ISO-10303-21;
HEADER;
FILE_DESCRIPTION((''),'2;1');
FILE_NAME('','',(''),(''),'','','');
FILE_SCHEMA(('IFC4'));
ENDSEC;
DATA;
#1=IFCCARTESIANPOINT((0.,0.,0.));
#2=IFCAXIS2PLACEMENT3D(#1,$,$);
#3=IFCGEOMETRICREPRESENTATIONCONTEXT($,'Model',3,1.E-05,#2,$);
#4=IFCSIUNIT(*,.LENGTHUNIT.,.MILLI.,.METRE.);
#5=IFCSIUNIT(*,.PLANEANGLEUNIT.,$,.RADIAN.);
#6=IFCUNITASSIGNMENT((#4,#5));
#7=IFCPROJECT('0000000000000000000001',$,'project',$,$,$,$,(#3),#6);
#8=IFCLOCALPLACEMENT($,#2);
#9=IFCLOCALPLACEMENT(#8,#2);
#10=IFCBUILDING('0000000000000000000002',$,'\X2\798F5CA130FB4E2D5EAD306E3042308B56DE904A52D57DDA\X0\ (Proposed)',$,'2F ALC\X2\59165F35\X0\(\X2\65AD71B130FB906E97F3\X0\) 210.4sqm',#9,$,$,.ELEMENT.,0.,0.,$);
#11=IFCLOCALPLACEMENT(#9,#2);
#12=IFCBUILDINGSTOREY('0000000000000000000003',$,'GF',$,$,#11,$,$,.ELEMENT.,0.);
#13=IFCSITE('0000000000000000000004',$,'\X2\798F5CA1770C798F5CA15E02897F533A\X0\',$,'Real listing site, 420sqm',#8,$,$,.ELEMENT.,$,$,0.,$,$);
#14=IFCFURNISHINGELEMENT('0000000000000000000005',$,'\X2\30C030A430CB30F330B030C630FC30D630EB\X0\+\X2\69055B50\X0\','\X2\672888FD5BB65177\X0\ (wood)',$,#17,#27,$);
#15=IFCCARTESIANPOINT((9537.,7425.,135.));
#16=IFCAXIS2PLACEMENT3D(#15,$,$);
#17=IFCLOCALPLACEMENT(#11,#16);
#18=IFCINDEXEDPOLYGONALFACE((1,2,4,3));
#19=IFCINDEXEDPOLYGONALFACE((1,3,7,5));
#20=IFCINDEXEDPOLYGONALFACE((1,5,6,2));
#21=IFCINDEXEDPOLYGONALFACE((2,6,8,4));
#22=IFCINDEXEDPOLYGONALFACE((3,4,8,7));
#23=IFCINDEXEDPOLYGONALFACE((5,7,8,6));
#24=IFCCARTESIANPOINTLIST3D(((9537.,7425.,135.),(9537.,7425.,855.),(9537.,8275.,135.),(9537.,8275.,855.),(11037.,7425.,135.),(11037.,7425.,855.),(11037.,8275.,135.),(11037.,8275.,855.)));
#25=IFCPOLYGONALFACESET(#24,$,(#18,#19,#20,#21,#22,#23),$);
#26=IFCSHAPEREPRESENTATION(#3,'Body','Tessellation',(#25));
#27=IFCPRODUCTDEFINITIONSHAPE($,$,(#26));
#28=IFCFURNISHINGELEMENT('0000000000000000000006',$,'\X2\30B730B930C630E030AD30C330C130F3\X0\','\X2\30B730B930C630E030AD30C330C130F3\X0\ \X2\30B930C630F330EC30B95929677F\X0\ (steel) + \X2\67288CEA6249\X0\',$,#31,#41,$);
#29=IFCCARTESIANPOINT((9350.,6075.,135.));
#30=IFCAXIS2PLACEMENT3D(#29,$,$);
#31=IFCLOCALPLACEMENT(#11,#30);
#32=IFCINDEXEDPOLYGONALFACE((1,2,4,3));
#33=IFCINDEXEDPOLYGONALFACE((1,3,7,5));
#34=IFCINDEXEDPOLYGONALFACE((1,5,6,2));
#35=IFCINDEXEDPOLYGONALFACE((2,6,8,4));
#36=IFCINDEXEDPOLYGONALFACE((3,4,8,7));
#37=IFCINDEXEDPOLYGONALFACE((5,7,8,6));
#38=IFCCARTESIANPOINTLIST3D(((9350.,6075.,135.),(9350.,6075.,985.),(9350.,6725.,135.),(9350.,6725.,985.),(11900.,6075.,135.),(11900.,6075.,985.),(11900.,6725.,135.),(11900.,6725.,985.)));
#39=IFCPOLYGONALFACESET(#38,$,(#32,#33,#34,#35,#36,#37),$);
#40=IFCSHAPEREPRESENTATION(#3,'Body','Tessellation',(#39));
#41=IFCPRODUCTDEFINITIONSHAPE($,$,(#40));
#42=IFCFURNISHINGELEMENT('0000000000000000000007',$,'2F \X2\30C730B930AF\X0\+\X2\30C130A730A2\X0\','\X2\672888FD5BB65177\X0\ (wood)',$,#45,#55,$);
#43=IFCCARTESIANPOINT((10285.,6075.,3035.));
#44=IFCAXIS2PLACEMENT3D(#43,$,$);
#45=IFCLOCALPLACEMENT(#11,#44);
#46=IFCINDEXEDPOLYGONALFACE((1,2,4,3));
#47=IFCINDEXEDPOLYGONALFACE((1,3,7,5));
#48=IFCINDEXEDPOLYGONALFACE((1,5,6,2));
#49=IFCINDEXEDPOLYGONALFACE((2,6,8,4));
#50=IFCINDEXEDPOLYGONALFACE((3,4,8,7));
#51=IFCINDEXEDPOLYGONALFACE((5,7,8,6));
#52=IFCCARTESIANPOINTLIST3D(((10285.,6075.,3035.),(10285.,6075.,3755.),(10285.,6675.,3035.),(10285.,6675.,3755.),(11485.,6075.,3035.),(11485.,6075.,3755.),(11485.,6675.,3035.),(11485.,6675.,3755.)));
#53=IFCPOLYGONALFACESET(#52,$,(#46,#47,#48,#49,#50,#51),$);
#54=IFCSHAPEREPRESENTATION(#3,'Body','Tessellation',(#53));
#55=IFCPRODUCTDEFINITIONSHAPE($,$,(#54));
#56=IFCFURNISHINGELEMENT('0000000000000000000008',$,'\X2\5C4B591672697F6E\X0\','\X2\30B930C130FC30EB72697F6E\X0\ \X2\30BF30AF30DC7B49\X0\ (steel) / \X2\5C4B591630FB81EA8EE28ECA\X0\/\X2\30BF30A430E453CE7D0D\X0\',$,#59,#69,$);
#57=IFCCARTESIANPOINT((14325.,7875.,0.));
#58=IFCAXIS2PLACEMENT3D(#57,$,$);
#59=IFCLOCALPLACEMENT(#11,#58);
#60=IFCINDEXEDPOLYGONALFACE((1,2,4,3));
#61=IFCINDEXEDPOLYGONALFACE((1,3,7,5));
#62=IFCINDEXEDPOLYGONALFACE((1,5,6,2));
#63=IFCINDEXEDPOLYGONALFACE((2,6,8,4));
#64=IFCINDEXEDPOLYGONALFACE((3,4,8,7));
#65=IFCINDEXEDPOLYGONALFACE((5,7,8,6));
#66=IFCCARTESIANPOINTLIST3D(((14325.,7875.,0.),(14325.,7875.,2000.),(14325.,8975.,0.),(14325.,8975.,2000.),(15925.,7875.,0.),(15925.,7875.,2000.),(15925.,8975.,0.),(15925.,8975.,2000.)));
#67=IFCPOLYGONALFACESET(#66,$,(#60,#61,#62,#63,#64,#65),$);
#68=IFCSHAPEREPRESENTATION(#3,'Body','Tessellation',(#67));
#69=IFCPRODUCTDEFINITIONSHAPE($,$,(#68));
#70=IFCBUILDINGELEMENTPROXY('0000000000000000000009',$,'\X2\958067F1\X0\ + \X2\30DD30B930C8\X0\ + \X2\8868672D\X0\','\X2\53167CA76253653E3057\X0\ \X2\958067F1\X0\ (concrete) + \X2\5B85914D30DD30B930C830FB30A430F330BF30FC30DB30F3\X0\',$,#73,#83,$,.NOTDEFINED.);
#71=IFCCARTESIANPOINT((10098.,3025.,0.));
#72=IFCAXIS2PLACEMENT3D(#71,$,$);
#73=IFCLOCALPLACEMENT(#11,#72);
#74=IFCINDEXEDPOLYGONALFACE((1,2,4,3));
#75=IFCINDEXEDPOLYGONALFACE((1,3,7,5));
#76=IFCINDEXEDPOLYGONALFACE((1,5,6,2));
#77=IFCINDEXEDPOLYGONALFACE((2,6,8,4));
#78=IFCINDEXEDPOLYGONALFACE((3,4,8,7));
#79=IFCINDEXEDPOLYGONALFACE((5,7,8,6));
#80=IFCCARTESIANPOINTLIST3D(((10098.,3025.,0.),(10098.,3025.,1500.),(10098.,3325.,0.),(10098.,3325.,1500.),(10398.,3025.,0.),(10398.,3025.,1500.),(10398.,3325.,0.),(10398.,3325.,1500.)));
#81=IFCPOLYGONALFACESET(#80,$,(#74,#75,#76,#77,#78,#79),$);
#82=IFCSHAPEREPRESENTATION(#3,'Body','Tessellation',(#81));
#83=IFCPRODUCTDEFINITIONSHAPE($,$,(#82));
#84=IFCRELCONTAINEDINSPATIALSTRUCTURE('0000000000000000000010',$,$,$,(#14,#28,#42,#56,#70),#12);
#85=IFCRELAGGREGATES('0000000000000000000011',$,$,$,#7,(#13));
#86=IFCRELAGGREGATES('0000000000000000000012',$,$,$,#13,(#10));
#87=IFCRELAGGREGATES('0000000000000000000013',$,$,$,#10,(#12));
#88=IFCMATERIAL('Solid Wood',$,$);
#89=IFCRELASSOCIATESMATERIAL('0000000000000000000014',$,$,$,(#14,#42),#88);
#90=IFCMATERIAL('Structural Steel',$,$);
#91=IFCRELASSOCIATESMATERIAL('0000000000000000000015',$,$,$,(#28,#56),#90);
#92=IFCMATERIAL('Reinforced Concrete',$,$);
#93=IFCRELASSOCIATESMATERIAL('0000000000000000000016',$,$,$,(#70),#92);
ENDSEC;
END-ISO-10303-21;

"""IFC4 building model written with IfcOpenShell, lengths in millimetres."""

from ifc_helpers import new_model, si_unit, frame, frame_2d, origin, place, context, project, spatial, rectangle, extrude, material, element, save


model = new_model("IFC4")

# Units and contexts
model_context = context("Model", 3, precision=1e-05, world=origin())
ifc_project = project(units=[si_unit("LENGTHUNIT", "METRE", prefix="MILLI"), si_unit("PLANEANGLEUNIT", "RADIAN")], contexts=[model_context])

# Site, building, storey
site_placement = place(None, origin())
site = spatial("IfcSite", under=ifc_project, at=site_placement, Name="福岡県福岡市西区", ObjectType="Real listing site, 420sqm", CompositionType="ELEMENT", RefElevation=0.0)
building_placement = place(site_placement, origin())
building = spatial("IfcBuilding", under=site, at=building_placement, Name="福岡・中庭のある回遊動線 (Proposed)", ObjectType="2F ALC外張(断熱・遮音) 210.4sqm", CompositionType="ELEMENT", ElevationOfRefHeight=0.0, ElevationOfTerrain=0.0)
storey_placement = place(building_placement, origin())
storey = spatial("IfcBuildingStorey", under=building, at=storey_placement, Name="GF", CompositionType="ELEMENT", Elevation=0.0)

# Shared definitions
ifc_material_1 = material(Name="Solid Wood")

# Shared definitions
ifc_material_2 = material(Name="Reinforced Concrete")

# Shared definitions
ifc_material_3 = material(Name="Structural Steel")

# Furnishing elements
furnishing_1_placement = place(storey_placement, frame((9537.0, 7425.0, 135.0)))
element("IfcFurnishingElement", 1, at=furnishing_1_placement, inside=storey, material=ifc_material_1, Name="ダイニングテーブル+椅子", Description="木製家具 (wood)", context=model_context, shape_type="SweptSolid", body=[
    extrude(rectangle(XDim=1500.0, YDim=850.0, at=frame_2d((750.0, 425.0))), frame((9537.0, 7425.0, 135.0)), (0.0, 0.0, 1.0), 720.0),
])
furnishing_2_placement = place(storey_placement, frame((9350.0, 6075.0, 135.0)))
element("IfcFurnishingElement", 2, at=furnishing_2_placement, inside=storey, material=ifc_material_3, Name="システムキッチン", Description="システムキッチン ステンレス天板 (steel) + 木質扉", context=model_context, shape_type="SweptSolid", body=[
    extrude(rectangle(XDim=2550.0, YDim=650.0, at=frame_2d((1275.0, 325.0))), frame((9350.0, 6075.0, 135.0)), (0.0, 0.0, 1.0), 850.0),
])
furnishing_3_placement = place(storey_placement, frame((10285.0, 6075.0, 3035.0)))
element("IfcFurnishingElement", 3, at=furnishing_3_placement, inside=storey, material=ifc_material_1, Name="2F デスク+チェア", Description="木製家具 (wood)", context=model_context, shape_type="SweptSolid", body=[
    extrude(rectangle(XDim=1200.0, YDim=600.0, at=frame_2d((600.0, 300.0))), frame((10285.0, 6075.0, 3035.0)), (0.0, 0.0, 1.0), 720.0),
])
furnishing_4_placement = place(storey_placement, frame((14325.0, 7875.0, 0.0)))
element("IfcFurnishingElement", 4, at=furnishing_4_placement, inside=storey, material=ifc_material_3, Name="屋外物置", Description="スチール物置 タクボ等 (steel) / 屋外・自転車/タイヤ収納", context=model_context, shape_type="SweptSolid", body=[
    extrude(rectangle(XDim=1600.0, YDim=1100.0, at=frame_2d((800.0, 550.0))), frame((14325.0, 7875.0, 0.0)), (0.0, 0.0, 1.0), 2000.0),
])

# Building element proxy
proxy_placement = place(storey_placement, frame((10098.0, 3025.0, 0.0)))
element("IfcBuildingElementProxy", 5, at=proxy_placement, inside=storey, material=ifc_material_2, Name="門柱 + ポスト + 表札", Description="化粧打放し 門柱 (concrete) + 宅配ポスト・インターホン", PredefinedType="NOTDEFINED", context=model_context, shape_type="SweptSolid", body=[
    extrude(rectangle(XDim=300.0, YDim=300.0, at=frame_2d((150.0, 150.0))), frame((10098.0, 3025.0, 0.0)), (0.0, 0.0, 1.0), 1500.0),
])

save(model, "model.ifc")
